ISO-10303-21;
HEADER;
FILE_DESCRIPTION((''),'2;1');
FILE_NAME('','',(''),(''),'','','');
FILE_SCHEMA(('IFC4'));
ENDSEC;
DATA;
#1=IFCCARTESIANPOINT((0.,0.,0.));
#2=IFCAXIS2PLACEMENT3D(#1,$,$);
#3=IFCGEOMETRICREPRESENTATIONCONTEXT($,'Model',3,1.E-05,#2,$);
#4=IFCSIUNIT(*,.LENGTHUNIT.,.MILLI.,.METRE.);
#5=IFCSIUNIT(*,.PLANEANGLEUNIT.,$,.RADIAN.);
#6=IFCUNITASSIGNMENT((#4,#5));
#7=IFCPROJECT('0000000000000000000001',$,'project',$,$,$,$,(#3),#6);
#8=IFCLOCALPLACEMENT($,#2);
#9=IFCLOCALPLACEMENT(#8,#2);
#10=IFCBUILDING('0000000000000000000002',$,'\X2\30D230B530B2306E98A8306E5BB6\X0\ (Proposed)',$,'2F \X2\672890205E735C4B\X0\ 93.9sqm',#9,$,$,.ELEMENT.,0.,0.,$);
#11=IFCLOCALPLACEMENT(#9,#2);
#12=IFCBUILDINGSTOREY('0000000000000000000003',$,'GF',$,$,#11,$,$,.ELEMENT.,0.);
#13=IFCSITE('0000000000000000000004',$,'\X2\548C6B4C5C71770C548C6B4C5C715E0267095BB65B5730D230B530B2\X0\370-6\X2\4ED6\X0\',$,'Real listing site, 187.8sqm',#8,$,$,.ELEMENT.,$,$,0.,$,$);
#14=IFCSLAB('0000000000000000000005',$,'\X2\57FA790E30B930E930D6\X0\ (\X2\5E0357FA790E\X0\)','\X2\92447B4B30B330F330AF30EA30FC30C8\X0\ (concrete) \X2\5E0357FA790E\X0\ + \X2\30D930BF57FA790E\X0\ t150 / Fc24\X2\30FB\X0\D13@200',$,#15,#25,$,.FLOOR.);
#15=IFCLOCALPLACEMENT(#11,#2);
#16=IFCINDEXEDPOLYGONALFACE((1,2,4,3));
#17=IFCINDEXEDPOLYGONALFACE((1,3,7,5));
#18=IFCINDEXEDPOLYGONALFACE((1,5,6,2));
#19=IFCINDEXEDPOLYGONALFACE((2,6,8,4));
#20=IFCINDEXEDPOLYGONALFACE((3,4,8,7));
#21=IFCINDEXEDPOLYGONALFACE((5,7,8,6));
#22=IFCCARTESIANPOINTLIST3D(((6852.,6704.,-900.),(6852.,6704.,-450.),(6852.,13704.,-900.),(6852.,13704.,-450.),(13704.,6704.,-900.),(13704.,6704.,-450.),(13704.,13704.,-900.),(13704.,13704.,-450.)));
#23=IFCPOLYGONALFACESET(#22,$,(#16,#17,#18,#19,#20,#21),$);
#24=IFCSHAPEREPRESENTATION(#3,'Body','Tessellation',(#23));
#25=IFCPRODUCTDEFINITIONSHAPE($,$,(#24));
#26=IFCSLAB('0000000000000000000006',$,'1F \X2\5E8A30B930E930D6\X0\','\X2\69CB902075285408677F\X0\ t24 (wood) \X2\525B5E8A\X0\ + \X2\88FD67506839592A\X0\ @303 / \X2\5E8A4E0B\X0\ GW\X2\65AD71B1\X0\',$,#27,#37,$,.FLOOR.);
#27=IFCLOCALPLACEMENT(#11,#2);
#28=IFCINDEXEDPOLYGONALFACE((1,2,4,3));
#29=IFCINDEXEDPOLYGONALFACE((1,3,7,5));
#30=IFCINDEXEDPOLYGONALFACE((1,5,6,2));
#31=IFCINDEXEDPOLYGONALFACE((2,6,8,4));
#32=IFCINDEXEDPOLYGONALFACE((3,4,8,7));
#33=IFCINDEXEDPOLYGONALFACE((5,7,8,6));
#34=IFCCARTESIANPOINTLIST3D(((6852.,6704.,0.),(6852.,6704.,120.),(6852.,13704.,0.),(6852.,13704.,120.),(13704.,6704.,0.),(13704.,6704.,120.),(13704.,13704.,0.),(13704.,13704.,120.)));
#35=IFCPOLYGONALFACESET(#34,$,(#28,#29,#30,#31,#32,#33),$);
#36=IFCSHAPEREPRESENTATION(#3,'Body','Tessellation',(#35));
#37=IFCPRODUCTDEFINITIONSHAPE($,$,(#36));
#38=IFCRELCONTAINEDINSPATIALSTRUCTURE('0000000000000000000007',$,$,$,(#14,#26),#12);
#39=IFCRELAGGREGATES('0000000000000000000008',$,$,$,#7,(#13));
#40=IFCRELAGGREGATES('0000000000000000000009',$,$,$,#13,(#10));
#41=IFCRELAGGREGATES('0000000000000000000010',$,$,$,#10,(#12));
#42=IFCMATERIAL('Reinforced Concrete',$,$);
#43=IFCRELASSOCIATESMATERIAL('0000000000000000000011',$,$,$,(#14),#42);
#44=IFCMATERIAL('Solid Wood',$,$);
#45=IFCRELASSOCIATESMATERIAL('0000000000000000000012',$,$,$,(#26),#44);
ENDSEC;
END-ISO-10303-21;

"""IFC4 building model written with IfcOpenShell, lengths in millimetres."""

from ifc_helpers import new_model, si_unit, frame, frame_2d, origin, place, context, project, spatial, rectangle, extrude, material, element, save


model = new_model("IFC4")

# Units and contexts
model_context = context("Model", 3, precision=1e-05, world=origin())
ifc_project = project(units=[si_unit("LENGTHUNIT", "METRE", prefix="MILLI"), si_unit("PLANEANGLEUNIT", "RADIAN")], contexts=[model_context])

# Site, building, storey
site_placement = place(None, origin())
site = spatial("IfcSite", under=ifc_project, at=site_placement, Name="和歌山県和歌山市有家字ヒサゲ370-6他", ObjectType="Real listing site, 187.8sqm", CompositionType="ELEMENT", RefElevation=0.0)
building_placement = place(site_placement, origin())
building = spatial("IfcBuilding", under=site, at=building_placement, Name="ヒサゲの風の家 (Proposed)", ObjectType="2F 木造平屋 93.9sqm", CompositionType="ELEMENT", ElevationOfRefHeight=0.0, ElevationOfTerrain=0.0)
storey_placement = place(building_placement, origin())
storey = spatial("IfcBuildingStorey", under=building, at=storey_placement, Name="GF", CompositionType="ELEMENT", Elevation=0.0)

# Slabs
ifc_material_1 = material(Name="Reinforced Concrete")
slab_1_placement = place(storey_placement, frame((3426.0, 3352.0, -450.0)))
element("IfcSlab", 1, at=slab_1_placement, inside=storey, material=ifc_material_1, Name="基礎スラブ (布基礎)", Description="鉄筋コンクリート (concrete) 布基礎 + ベタ基礎 t150 / Fc24・D13@200", PredefinedType="FLOOR", context=model_context, shape_type="SweptSolid", body=[
    extrude(rectangle(XDim=6852.0, YDim=7000.0, at=frame_2d((3426.0, 3500.0))), frame((3426.0, 3352.0, -450.0)), (0.0, 0.0, 1.0), 450.0),
])
ifc_material_2 = material(Name="Solid Wood")
slab_2_placement = place(storey_placement, frame((3426.0, 3352.0, 0.0)))
element("IfcSlab", 2, at=slab_2_placement, inside=storey, material=ifc_material_2, Name="1F 床スラブ", Description="構造用合板 t24 (wood) 剛床 + 製材根太 @303 / 床下 GW断熱", PredefinedType="FLOOR", context=model_context, shape_type="SweptSolid", body=[
    extrude(rectangle(XDim=6852.0, YDim=7000.0, at=frame_2d((3426.0, 3500.0))), frame((3426.0, 3352.0, 0.0)), (0.0, 0.0, 1.0), 120.0),
])

save(model, "model.ifc")
